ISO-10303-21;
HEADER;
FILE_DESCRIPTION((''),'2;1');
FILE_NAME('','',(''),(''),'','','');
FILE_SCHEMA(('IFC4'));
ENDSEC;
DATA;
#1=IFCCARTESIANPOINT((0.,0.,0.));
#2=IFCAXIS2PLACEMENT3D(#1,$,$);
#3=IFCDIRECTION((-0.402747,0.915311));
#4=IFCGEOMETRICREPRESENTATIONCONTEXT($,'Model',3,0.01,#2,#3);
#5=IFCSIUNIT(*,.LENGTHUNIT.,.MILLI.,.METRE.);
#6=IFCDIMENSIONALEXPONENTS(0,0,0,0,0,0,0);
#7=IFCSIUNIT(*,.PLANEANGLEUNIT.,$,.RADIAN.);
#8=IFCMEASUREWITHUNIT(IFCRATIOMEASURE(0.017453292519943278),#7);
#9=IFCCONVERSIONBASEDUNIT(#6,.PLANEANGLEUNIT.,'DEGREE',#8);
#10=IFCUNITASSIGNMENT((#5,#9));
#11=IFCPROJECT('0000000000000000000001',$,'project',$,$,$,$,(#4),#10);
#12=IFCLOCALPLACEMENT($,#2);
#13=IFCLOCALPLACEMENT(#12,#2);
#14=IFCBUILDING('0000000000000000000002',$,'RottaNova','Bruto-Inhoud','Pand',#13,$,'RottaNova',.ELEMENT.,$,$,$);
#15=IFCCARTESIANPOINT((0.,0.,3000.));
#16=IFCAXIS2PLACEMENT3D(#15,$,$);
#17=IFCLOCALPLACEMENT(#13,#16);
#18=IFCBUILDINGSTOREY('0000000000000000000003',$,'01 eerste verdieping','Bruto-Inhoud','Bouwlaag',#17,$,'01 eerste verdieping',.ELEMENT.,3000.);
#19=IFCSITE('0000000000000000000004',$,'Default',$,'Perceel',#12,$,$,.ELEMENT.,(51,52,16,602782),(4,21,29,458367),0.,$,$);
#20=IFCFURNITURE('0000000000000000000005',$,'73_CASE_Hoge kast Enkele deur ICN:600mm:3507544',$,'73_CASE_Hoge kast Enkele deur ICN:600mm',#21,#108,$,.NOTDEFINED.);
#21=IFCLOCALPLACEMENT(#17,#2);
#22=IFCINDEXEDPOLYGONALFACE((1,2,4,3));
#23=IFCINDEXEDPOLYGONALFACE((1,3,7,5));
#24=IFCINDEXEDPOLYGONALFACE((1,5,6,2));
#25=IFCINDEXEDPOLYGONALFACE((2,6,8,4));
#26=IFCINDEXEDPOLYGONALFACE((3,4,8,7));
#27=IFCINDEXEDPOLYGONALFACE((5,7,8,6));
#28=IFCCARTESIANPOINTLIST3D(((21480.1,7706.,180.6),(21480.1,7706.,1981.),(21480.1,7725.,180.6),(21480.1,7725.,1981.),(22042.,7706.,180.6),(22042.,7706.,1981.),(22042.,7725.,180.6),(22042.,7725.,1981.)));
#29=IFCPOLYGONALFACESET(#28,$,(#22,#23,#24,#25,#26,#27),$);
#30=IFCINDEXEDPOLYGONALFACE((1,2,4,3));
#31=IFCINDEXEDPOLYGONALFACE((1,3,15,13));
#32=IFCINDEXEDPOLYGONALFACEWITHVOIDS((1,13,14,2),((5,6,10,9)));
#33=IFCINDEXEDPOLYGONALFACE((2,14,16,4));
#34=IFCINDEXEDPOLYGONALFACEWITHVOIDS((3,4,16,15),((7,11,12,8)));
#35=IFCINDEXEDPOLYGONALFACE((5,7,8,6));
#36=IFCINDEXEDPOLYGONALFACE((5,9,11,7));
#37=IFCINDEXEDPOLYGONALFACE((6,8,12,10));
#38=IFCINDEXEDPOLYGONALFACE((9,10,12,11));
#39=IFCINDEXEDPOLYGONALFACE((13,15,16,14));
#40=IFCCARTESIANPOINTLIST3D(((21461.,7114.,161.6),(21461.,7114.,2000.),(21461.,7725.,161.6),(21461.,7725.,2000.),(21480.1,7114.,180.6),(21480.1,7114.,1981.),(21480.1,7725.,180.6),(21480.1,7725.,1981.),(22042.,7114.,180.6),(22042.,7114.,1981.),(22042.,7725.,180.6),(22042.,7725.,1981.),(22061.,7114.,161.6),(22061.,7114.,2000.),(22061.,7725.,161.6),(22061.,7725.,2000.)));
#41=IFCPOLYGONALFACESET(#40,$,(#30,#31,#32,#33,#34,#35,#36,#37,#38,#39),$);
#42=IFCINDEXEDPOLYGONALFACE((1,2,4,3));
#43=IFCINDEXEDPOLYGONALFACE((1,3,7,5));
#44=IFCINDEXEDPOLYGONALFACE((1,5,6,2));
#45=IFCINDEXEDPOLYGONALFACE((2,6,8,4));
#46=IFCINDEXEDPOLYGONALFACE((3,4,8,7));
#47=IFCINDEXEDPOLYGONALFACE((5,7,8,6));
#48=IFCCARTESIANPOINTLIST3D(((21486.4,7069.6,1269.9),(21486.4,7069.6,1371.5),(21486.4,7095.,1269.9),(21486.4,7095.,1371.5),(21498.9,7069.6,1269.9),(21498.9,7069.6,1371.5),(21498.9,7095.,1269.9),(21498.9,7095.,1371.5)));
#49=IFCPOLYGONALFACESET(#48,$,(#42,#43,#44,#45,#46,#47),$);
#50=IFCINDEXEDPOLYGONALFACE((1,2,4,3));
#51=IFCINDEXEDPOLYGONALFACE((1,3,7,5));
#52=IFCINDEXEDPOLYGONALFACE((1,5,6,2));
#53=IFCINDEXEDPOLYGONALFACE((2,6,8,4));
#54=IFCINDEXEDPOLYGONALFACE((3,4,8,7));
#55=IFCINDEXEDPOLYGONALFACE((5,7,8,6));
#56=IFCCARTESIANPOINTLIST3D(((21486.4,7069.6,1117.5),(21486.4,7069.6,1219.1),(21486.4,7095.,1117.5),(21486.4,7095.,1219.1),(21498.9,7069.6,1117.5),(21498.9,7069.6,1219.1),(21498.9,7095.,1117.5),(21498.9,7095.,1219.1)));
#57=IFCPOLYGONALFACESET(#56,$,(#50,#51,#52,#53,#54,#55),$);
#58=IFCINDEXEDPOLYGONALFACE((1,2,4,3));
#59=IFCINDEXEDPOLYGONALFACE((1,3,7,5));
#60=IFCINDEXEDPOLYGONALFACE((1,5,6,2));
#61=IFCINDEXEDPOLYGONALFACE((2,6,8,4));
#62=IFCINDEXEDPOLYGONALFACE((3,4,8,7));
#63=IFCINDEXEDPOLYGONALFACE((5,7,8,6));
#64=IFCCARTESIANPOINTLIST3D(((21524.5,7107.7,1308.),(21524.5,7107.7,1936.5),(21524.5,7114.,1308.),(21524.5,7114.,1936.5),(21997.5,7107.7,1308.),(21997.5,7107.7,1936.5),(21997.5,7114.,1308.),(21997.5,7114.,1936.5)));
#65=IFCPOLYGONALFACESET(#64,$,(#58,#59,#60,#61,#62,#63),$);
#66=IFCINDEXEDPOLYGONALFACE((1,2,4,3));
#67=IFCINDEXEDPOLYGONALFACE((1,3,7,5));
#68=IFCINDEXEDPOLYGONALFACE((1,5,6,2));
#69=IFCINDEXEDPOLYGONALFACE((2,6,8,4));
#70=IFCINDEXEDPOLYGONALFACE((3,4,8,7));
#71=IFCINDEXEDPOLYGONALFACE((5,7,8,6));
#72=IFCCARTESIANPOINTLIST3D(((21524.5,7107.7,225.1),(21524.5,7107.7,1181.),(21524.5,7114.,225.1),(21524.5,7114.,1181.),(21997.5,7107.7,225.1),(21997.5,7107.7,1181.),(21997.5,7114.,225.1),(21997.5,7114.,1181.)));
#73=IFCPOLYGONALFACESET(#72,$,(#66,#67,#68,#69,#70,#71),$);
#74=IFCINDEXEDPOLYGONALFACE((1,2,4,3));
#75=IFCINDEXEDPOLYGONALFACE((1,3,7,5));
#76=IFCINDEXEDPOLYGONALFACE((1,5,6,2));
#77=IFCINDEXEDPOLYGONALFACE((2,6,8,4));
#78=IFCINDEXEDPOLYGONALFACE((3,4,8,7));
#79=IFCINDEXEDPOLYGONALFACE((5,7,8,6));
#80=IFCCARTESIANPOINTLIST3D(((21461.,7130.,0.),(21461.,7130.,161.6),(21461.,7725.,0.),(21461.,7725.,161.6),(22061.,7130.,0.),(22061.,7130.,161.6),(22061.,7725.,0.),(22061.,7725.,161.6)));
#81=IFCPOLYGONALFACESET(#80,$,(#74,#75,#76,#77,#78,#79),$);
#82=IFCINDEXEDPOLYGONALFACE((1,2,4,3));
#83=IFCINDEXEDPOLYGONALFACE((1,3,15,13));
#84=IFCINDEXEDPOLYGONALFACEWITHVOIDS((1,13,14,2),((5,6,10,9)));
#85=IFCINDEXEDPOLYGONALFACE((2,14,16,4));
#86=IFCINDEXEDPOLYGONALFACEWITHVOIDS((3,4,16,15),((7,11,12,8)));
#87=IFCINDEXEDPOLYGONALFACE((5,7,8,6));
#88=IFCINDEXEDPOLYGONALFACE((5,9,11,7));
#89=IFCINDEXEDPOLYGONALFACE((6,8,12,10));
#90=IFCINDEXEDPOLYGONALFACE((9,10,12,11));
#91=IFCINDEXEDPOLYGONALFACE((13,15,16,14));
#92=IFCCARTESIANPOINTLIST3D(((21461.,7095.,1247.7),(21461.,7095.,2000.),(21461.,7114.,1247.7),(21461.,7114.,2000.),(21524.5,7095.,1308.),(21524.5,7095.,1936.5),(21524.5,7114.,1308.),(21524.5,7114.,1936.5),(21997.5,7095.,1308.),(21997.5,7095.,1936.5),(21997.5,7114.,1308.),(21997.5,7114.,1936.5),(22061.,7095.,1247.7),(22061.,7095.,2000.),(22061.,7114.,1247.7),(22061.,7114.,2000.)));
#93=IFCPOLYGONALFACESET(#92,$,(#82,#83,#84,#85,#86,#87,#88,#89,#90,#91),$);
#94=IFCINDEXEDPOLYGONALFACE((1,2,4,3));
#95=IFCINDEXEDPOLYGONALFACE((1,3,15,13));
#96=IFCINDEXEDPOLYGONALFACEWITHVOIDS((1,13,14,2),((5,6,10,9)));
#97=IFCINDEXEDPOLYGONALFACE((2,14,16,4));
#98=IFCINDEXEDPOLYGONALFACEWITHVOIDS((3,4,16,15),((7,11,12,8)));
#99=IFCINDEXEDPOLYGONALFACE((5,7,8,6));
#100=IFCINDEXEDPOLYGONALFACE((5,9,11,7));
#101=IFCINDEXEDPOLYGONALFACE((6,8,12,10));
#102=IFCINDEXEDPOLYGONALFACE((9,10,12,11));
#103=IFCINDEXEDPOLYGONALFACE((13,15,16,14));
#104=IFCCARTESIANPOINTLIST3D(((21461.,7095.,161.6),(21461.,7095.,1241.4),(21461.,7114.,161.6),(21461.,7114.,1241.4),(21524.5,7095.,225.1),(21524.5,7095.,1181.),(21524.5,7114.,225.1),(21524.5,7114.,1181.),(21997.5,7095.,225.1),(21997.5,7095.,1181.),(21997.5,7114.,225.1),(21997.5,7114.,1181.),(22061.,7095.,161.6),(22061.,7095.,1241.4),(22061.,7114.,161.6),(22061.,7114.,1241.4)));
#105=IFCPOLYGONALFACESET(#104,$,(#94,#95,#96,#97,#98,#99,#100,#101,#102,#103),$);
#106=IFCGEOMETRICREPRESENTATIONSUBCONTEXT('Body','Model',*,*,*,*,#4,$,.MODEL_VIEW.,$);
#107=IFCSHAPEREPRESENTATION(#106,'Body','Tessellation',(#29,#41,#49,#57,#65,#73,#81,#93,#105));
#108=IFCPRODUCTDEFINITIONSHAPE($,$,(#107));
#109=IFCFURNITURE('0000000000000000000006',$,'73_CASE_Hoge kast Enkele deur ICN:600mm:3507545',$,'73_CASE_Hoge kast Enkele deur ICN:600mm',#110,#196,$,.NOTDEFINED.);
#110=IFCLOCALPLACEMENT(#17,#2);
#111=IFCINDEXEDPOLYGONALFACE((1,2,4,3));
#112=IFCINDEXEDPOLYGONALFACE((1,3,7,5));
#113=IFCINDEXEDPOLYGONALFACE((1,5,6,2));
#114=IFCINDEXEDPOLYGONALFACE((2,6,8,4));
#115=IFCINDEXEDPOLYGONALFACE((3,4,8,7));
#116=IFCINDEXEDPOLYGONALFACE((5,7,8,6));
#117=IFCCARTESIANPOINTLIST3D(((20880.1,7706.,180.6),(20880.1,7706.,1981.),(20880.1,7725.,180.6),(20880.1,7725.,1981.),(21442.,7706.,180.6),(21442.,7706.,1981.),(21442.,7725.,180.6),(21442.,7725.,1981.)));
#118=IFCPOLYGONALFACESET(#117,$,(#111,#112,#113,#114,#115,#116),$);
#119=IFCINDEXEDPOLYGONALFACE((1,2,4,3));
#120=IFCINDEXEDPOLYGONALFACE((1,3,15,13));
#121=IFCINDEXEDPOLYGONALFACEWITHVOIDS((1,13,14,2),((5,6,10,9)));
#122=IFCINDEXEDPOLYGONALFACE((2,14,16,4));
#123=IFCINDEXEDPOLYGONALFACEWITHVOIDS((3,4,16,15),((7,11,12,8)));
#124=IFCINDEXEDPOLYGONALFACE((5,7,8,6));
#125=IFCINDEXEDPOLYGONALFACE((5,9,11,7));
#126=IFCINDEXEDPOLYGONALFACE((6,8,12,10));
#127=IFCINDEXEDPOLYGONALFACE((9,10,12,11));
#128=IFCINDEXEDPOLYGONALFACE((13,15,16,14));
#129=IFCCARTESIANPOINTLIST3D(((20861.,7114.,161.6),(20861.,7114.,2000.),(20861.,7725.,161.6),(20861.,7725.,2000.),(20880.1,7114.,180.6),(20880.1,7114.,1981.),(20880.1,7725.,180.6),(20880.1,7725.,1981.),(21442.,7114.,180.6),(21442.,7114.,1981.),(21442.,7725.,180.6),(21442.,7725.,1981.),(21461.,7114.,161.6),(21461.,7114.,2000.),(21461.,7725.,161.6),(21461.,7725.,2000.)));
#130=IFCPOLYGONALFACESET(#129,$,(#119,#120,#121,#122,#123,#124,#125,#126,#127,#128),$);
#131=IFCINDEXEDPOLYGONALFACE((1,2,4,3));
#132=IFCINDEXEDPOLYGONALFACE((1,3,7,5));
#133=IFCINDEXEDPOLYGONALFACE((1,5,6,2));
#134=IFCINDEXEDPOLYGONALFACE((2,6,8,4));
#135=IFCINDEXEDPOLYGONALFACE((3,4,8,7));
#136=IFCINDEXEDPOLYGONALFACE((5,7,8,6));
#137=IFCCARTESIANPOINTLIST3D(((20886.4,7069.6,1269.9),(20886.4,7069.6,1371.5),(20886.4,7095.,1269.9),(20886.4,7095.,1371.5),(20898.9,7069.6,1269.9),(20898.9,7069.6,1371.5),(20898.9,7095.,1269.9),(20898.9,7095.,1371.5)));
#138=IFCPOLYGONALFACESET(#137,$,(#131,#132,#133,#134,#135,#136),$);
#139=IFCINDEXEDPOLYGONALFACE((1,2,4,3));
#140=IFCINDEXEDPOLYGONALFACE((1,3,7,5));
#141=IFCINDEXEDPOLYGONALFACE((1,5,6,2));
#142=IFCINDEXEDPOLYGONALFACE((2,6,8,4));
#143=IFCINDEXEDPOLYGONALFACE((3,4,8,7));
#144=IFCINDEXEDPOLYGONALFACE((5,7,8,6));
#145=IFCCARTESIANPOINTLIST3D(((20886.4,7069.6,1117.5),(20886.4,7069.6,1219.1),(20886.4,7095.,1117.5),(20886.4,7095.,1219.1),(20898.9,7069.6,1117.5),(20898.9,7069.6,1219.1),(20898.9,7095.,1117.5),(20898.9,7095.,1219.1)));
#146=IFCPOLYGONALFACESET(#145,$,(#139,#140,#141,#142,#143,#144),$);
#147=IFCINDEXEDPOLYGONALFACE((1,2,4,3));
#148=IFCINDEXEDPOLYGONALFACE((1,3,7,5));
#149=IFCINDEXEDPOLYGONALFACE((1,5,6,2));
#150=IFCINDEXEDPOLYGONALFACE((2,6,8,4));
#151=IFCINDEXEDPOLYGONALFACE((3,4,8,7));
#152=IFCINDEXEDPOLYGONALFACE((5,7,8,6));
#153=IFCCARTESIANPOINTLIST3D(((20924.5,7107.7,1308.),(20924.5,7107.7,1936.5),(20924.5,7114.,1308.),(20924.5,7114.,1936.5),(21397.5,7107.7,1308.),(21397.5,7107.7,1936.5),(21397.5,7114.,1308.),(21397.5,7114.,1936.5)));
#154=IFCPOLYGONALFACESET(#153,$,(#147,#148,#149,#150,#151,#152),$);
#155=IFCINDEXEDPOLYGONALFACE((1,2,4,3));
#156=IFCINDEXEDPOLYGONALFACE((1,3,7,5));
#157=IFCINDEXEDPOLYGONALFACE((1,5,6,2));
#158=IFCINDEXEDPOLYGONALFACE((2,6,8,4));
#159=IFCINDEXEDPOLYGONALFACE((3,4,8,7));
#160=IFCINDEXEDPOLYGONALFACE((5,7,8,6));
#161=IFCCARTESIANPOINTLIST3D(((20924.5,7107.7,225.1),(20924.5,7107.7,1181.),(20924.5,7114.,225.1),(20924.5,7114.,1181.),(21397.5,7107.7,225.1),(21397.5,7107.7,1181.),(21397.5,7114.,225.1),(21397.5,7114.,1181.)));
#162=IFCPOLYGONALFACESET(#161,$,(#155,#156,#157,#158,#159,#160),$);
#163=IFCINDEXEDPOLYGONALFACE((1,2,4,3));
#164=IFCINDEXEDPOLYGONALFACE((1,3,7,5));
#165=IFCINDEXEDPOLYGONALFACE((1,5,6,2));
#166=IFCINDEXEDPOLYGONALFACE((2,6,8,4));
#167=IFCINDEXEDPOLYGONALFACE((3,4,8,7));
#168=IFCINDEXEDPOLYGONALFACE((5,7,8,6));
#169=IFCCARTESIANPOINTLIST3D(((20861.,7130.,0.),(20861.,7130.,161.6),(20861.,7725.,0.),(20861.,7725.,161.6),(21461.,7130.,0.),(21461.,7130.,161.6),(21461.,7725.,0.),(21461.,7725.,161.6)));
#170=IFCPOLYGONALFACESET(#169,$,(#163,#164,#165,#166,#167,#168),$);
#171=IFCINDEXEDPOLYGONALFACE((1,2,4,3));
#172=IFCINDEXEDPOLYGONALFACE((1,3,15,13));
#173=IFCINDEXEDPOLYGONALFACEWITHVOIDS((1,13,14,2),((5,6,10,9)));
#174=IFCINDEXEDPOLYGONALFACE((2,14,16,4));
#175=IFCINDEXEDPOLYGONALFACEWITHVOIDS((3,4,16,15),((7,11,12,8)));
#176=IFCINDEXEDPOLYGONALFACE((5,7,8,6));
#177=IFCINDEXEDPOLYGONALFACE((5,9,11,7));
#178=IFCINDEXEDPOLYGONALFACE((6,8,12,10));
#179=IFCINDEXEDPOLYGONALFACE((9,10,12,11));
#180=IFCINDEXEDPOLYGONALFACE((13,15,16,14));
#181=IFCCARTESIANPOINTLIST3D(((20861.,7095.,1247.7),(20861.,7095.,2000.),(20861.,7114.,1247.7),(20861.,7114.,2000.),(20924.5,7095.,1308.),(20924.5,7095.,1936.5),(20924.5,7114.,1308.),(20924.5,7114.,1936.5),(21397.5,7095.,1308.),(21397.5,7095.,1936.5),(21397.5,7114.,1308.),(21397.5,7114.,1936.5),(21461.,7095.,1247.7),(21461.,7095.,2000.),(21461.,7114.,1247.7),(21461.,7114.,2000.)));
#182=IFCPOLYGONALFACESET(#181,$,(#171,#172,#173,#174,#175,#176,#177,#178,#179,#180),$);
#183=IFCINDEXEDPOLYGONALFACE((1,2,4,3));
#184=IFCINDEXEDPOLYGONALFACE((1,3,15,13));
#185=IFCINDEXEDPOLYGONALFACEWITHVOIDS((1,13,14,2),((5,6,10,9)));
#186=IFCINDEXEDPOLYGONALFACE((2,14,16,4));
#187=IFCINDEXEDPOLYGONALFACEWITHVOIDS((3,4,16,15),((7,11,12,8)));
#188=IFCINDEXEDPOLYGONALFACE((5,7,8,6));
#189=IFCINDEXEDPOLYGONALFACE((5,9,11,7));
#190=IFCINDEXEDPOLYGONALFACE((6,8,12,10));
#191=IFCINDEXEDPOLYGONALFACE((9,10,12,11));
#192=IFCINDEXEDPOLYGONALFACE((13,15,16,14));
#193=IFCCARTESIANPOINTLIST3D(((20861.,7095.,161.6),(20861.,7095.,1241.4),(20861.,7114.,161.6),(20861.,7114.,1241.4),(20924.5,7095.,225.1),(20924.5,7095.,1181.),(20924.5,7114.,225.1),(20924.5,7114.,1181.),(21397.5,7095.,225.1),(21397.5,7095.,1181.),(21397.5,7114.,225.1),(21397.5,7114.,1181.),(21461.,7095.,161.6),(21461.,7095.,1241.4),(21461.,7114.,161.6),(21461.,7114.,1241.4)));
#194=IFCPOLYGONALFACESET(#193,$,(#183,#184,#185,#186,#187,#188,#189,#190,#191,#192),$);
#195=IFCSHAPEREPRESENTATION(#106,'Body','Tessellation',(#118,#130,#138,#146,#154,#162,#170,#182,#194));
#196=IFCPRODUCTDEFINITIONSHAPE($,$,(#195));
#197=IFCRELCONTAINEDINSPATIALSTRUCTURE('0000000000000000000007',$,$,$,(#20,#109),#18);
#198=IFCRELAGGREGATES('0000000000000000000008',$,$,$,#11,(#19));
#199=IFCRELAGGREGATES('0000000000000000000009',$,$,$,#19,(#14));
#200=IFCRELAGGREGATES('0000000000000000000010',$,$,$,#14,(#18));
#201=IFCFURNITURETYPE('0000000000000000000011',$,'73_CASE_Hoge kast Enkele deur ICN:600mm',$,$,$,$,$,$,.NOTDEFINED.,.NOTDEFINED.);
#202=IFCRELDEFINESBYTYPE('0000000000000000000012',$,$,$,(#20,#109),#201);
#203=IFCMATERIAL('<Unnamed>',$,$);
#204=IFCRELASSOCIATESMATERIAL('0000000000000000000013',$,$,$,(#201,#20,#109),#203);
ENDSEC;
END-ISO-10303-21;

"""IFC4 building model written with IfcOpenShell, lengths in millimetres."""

from ifc_helpers import new_model, entity, si_unit, converted_unit, direction, frame, frame_2d, origin, origin_2d_with_axis, place, context, subcontext, project, spatial, polyline, rectangle, outline, extrude, source, transform, mapped, material, type_object, type_shapes, element, save


model = new_model("IFC4")

# Units and contexts
model_context = context("Model", 3, precision=0.01, world=origin(), true_north=direction((-0.402747, 0.915311)))
body_context = subcontext(model_context, "Body", "Model", "MODEL_VIEW")
ifc_project = project(units=[si_unit("LENGTHUNIT", "METRE", prefix="MILLI"), converted_unit("PLANEANGLEUNIT", "DEGREE", entity("IfcRatioMeasure", 0.017453292519943278), si_unit("PLANEANGLEUNIT", "RADIAN"), dimensions=[0, 0, 0, 0, 0, 0, 0])], contexts=[model_context])

# Site, building, storey
site_placement = place(None, origin())
site = spatial("IfcSite", under=ifc_project, at=site_placement, Name="Default", ObjectType="Perceel", CompositionType="ELEMENT", RefLatitude=(51, 52, 16, 602782), RefLongitude=(4, 21, 29, 458367), RefElevation=0.0)
building_placement = place(site_placement, origin())
building = spatial("IfcBuilding", under=site, at=building_placement, Name="RottaNova", Description="Bruto-Inhoud", ObjectType="Pand", LongName="RottaNova", CompositionType="ELEMENT")
storey_placement = place(building_placement, frame((0.0, 0.0, 3000.0)))
storey = spatial("IfcBuildingStorey", under=building, at=storey_placement, Name="01 eerste verdieping", Description="Bruto-Inhoud", ObjectType="Bouwlaag", LongName="01 eerste verdieping", CompositionType="ELEMENT", Elevation=3000.0)

# Furniture
ifc_material_1 = material(Name="<Unnamed>")
furniture_type = type_object("IfcFurnitureType", Name="73_CASE_Hoge kast Enkele deur ICN:600mm", AssemblyPlace="NOTDEFINED", PredefinedType="NOTDEFINED", material=ifc_material_1)
shared_shape_1 = source(origin(), body_context, "Body", "SweptSolid", [
    extrude(rectangle(XDim=561.9, YDim=19.1, at=origin_2d_with_axis()), frame((18.7, 9.5, 180.6), z_axis=(0.0, 0.0, 1.0), x_axis=(-1.0, 0.0, 0.0)), (0.0, 0.0, 1.0), 1800.3),
    extrude(outline(polyline([(-300.0, -919.2), (300.0, -919.2), (300.0, 919.2), (-300.0, 919.2), (-300.0, -919.2)]), holes=[polyline([(-280.9, 900.2), (281.0, 900.2), (281.0, -900.2), (-280.9, -900.2), (-280.9, 900.2)])]), frame((18.7, 0.0, 1080.8), z_axis=(0.0, 1.0, 0.0), x_axis=(-1.0, 0.0, 0.0)), (0.0, 0.0, 1.0), 610.9),
    extrude(rectangle(XDim=12.5, YDim=25.4, at=frame_2d((0.0, 0.0), x_axis=(1.0, 0.0))), frame((287.1, 642.7, 1269.9), z_axis=(0.0, 0.0, 1.0), x_axis=(-1.0, 0.0, 0.0)), (0.0, 0.0, 1.0), 101.6),
    extrude(rectangle(XDim=12.5, YDim=25.4, at=frame_2d((0.0, 0.0), x_axis=(1.0, 0.0))), frame((287.1, 642.7, 1117.5), z_axis=(0.0, 0.0, 1.0), x_axis=(-1.0, 0.0, 0.0)), (0.0, 0.0, 1.0), 101.6),
    extrude(rectangle(XDim=473.0, YDim=6.4, at=origin_2d_with_axis()), frame((18.7, 614.1, 1308.0), z_axis=(0.0, 0.0, 1.0), x_axis=(-1.0, 0.0, 0.0)), (0.0, 0.0, 1.0), 628.5),
    extrude(rectangle(XDim=473.0, YDim=6.4, at=origin_2d_with_axis()), frame((18.7, 614.1, 225.1), z_axis=(0.0, 0.0, 1.0), x_axis=(-1.0, 0.0, 0.0)), (0.0, 0.0, 1.0), 956.0),
    extrude(rectangle(XDim=595.0, YDim=600.0, at=frame_2d((0.0, 0.0), x_axis=(1.0, 0.0))), frame((18.7, 297.5, 0.0), z_axis=(0.0, 0.0, 1.0), x_axis=(0.0, 1.0, 0.0)), (0.0, 0.0, 1.0), 161.6),
    extrude(outline(polyline([(-376.1, -300.0), (376.1, -300.0), (376.1, 300.0), (-376.1, 300.0), (-376.1, -300.0)]), holes=[polyline([(-312.6, -236.5), (-312.6, 236.5), (315.8, 236.5), (315.8, -236.5), (-312.6, -236.5)])]), frame((18.7, 610.9, 1623.9), z_axis=(0.0, 1.0, 0.0), x_axis=(0.0, 0.0, -1.0)), (0.0, 0.0, 1.0), 19.1),
    extrude(outline(polyline([(-300.0, -539.9), (300.0, -539.9), (300.0, 539.9), (-300.0, 539.9), (-300.0, -539.9)]), holes=[polyline([(-236.5, 479.6), (236.5, 479.6), (236.5, -476.4), (-236.5, -476.4), (-236.5, 479.6)])]), frame((18.7, 610.9, 701.5), z_axis=(0.0, 1.0, 0.0), x_axis=(-1.0, 0.0, 0.0)), (0.0, 0.0, 1.0), 19.1),
])
type_shapes(furniture_type, [shared_shape_1])
for number, where, z_axis, x_axis, name in (
    (1, (21779.7, 7725.0, 0.0), (0.0, 0.0, 1.0), (-1.0, 0.0, 0.0), "73_CASE_Hoge kast Enkele deur ICN:600mm:3507544"),
    (2, (21179.7, 7725.0, 0.0), (0.0, 0.0, 1.0), (-1.0, 0.0, 0.0), "73_CASE_Hoge kast Enkele deur ICN:600mm:3507545"),
):
    element("IfcFurniture", number, at=place(storey_placement, frame(where, z_axis=z_axis, x_axis=x_axis)), inside=storey, type_object=furniture_type, material=ifc_material_1, Name=name, ObjectType="73_CASE_Hoge kast Enkele deur ICN:600mm", PredefinedType="NOTDEFINED", context=body_context, shape_type="MappedRepresentation", body=[
        mapped(shared_shape_1, transform((0.0, 0.0, 0.0), scale=1.0)),
    ])

save(model, "model.ifc")
